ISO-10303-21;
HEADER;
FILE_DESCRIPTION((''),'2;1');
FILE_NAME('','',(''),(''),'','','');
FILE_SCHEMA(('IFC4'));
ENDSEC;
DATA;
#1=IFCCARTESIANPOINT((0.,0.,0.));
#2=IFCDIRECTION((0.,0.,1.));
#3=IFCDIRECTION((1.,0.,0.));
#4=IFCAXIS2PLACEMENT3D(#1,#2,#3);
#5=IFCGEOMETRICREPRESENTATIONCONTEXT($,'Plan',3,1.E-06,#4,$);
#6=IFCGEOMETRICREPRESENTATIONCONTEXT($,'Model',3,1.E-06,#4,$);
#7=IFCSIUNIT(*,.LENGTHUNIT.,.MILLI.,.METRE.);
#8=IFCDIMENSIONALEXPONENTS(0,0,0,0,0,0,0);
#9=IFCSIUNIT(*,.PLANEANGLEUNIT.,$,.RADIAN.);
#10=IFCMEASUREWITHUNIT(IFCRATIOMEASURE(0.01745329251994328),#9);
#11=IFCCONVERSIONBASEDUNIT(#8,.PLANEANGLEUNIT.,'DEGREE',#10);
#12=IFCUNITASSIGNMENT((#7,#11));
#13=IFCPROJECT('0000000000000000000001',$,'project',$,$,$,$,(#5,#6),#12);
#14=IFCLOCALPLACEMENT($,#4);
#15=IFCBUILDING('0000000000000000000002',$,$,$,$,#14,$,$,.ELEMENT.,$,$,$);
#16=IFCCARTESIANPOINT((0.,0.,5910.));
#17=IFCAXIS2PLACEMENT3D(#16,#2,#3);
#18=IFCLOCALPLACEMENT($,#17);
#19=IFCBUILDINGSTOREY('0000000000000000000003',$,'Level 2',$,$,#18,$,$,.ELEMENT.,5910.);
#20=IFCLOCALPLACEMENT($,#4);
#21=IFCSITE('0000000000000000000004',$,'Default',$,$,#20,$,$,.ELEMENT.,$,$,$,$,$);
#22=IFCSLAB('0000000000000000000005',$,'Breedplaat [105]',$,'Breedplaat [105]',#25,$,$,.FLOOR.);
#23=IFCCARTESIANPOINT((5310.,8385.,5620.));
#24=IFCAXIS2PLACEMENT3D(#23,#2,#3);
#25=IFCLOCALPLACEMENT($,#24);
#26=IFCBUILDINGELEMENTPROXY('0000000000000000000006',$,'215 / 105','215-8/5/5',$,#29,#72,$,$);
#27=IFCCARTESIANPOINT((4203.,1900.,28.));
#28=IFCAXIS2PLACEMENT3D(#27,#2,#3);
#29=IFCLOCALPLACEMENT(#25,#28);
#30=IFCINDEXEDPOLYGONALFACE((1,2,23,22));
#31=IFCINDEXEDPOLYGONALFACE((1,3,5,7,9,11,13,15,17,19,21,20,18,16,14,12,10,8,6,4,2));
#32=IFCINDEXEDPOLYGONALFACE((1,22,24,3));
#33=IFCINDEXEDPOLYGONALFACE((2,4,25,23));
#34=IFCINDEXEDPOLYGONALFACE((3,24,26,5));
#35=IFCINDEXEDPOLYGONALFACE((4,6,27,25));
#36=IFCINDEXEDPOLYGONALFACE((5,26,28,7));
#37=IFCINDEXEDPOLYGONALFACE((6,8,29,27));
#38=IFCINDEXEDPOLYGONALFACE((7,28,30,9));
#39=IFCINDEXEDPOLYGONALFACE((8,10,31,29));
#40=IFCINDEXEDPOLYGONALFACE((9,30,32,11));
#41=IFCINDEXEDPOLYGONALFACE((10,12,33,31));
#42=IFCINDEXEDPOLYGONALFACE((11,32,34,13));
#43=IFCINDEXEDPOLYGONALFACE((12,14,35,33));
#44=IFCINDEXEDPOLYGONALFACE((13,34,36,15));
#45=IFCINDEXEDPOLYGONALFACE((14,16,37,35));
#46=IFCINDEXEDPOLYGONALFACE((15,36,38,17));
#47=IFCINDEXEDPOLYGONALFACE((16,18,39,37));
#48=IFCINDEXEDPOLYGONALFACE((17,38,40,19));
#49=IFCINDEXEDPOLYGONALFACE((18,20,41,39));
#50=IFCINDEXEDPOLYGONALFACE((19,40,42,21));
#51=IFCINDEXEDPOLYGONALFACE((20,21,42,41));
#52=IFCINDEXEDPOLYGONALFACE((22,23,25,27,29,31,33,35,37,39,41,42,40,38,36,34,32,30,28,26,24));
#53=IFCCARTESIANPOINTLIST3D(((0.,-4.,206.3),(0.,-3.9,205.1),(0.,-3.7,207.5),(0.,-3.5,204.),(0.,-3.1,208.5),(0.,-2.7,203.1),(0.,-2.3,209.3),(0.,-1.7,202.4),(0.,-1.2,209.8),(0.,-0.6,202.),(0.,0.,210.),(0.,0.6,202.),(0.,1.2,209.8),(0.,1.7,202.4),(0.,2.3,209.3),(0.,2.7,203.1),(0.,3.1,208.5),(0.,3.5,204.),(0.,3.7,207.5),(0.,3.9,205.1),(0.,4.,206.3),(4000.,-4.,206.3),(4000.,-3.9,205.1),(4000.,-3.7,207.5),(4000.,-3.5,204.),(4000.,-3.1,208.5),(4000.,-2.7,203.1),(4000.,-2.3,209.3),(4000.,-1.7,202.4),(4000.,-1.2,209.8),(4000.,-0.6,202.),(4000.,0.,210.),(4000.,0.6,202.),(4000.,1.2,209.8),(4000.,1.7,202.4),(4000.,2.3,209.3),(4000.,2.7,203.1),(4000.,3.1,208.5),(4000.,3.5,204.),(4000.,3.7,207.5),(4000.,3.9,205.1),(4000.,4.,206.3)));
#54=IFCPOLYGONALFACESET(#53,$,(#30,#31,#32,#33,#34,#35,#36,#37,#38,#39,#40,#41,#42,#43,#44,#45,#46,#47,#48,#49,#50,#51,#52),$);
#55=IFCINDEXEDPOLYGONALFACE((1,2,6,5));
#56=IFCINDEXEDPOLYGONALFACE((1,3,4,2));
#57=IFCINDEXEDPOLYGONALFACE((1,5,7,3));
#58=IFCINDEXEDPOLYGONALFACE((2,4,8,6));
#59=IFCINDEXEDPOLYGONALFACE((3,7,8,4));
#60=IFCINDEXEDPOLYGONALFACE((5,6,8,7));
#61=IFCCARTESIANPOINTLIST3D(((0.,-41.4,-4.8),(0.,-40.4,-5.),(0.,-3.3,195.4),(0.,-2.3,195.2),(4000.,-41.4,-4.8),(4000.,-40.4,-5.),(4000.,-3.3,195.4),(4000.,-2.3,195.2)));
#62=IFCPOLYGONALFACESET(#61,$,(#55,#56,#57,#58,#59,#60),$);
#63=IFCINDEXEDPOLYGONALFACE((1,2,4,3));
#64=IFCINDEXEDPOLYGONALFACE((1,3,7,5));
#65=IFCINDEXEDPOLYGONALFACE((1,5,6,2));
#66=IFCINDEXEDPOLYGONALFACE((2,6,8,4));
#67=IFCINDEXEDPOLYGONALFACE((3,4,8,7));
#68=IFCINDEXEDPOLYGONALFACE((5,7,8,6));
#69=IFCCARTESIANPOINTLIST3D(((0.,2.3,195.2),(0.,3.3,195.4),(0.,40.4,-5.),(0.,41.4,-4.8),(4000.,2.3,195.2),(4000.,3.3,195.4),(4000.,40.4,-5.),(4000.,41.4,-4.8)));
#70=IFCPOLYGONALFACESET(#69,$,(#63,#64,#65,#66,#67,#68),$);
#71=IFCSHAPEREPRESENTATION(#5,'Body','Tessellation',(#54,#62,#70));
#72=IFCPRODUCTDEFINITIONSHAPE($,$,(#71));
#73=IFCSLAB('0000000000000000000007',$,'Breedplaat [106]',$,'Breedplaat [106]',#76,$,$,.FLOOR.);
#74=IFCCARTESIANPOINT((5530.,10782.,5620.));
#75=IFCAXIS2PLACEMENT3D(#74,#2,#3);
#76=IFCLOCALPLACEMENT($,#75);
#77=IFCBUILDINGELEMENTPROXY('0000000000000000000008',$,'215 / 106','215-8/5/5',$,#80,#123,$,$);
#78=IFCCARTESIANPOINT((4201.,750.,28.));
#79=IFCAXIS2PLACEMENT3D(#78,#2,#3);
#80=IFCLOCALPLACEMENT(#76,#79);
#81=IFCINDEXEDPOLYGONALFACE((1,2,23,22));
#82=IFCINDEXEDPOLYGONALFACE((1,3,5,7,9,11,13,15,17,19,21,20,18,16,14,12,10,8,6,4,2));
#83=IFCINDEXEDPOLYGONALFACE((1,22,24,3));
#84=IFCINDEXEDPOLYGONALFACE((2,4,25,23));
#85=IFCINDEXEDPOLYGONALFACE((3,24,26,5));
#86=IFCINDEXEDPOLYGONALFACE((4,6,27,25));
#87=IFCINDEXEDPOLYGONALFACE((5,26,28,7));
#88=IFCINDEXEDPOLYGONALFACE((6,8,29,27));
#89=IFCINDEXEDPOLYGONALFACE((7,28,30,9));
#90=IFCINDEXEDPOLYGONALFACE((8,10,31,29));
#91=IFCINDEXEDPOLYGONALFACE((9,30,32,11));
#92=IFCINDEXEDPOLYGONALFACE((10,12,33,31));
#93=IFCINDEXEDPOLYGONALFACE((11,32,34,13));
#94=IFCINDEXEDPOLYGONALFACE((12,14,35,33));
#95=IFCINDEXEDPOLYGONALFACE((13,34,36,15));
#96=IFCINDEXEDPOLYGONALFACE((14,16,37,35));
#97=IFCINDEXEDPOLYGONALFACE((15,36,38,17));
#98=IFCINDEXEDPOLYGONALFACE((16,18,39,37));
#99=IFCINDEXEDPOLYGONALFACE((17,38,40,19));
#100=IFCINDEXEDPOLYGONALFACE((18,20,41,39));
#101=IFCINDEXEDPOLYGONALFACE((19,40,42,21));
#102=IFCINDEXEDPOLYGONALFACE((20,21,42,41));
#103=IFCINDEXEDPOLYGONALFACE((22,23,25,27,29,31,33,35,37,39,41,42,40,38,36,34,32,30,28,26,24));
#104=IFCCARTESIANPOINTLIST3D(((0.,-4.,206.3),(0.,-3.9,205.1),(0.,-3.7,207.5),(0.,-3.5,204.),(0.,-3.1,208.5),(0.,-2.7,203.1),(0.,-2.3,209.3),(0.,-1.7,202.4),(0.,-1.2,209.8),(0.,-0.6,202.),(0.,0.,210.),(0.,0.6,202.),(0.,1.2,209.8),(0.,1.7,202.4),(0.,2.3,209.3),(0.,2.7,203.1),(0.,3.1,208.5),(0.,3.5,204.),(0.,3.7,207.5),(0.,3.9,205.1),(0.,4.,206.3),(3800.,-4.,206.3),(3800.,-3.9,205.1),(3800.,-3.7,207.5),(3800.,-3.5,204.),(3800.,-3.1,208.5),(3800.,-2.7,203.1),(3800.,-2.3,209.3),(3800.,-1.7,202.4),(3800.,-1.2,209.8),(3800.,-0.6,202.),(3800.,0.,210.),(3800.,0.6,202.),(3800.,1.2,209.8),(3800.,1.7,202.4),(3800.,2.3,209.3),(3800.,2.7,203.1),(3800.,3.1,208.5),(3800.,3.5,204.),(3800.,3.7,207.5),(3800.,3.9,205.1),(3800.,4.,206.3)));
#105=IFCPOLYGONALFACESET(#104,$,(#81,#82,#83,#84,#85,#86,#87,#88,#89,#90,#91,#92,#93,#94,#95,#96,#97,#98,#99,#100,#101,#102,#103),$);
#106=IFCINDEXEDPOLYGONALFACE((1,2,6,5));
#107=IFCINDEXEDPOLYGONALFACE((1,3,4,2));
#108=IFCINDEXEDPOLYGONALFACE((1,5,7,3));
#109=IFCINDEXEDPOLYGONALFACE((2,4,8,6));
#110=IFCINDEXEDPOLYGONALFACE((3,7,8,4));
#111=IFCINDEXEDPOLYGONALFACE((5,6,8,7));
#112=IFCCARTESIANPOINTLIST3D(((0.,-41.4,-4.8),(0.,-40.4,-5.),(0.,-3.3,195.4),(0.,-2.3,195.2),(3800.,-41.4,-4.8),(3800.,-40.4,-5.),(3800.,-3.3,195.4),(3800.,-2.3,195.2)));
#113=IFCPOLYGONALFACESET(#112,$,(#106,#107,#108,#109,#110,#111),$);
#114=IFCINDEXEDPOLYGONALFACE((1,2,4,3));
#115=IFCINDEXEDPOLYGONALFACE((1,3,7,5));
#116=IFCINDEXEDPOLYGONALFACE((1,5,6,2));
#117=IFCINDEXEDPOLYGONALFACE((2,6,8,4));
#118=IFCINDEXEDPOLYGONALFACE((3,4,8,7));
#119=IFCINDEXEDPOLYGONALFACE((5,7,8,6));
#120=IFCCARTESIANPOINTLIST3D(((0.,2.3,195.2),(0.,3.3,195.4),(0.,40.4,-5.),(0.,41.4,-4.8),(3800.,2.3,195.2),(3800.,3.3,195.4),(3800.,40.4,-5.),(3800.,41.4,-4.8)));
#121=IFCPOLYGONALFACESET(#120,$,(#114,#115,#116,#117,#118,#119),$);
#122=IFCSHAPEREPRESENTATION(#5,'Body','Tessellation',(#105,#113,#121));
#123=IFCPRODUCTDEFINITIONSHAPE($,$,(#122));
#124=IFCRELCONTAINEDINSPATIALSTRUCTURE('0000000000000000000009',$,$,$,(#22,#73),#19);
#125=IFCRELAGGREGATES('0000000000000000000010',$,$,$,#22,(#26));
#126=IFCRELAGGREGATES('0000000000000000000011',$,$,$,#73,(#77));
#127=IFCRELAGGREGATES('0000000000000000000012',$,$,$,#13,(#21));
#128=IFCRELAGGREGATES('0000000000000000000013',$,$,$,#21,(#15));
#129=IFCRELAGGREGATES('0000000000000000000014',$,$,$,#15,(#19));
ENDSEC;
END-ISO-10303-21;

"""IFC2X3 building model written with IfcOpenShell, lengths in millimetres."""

from ifc_helpers import new_model, entity, si_unit, converted_unit, frame, origin_with_axes, origin_2d_with_axis, place, context, project, spatial, rectangle, circle, extrude, element, aggregate, save


model = new_model("IFC2X3")

# Units and contexts
plan_context = context("Plan", 3, precision=1e-06, world=origin_with_axes())
model_context = context("Model", 3, precision=1e-06, world=origin_with_axes())
ifc_project = project(units=[si_unit("LENGTHUNIT", "METRE", prefix="MILLI"), converted_unit("PLANEANGLEUNIT", "DEGREE", entity("IfcRatioMeasure", 0.01745329251994328), si_unit("PLANEANGLEUNIT", "RADIAN"), dimensions=[0, 0, 0, 0, 0, 0, 0])], contexts=[plan_context, model_context])

# Site, building, storey
site_placement = place(None, origin_with_axes())
site = spatial("IfcSite", under=ifc_project, at=site_placement, Name="Default", CompositionType="ELEMENT")
building_placement = place(None, origin_with_axes())
building = spatial("IfcBuilding", under=site, at=building_placement, CompositionType="ELEMENT")
storey_placement = place(None, frame((0.0, 0.0, 5910.0), z_axis=(0.0, 0.0, 1.0), x_axis=(1.0, 0.0, 0.0)))
storey = spatial("IfcBuildingStorey", under=building, at=storey_placement, Name="Level 2", CompositionType="ELEMENT", Elevation=5910.0)

# Slabs, building element proxies
slab_1_placement = place(None, frame((5310.0, 8385.0, 5620.0), z_axis=(0.0, 0.0, 1.0), x_axis=(1.0, 0.0, 0.0)))
slab_1 = element("IfcSlab", 1, at=slab_1_placement, inside=storey, Name="Breedplaat [105]", ObjectType="Breedplaat [105]", PredefinedType="FLOOR")
proxy_1_placement = place(slab_1_placement, frame((4203.0, 1900.0, 28.0), z_axis=(0.0, 0.0, 1.0), x_axis=(1.0, 0.0, 0.0)))
proxy_1 = element("IfcBuildingElementProxy", 2, at=proxy_1_placement, Name="215 / 105", Description="215-8/5/5", context=plan_context, shape_type="SweptSolid", body=[
    extrude(circle(Radius=4.0, at=origin_2d_with_axis()), frame((0.0, 0.0, 206.0), z_axis=(1.0, 0.0, 0.0), x_axis=(0.0, 0.0, 1.0)), (0.0, 0.0, 1.0), 4000.0),
    extrude(rectangle(XDim=203.8, YDim=1.0, at=origin_2d_with_axis()), frame((0.0, -21.9, 95.2), z_axis=(1.0, 0.0, 0.0), x_axis=(0.0, 0.187112, 0.982339)), (0.0, 0.0, 1.0), 4000.0),
    extrude(rectangle(XDim=203.8, YDim=1.0, at=origin_2d_with_axis()), frame((0.0, 21.9, 95.2), z_axis=(1.0, 0.0, 0.0), x_axis=(0.0, -0.187112, 0.982339)), (0.0, 0.0, 1.0), 4000.0),
])
aggregate(slab_1, [proxy_1])
slab_2_placement = place(None, frame((5530.0, 10782.0, 5620.0), z_axis=(0.0, 0.0, 1.0), x_axis=(1.0, 0.0, 0.0)))
slab_2 = element("IfcSlab", 3, at=slab_2_placement, inside=storey, Name="Breedplaat [106]", ObjectType="Breedplaat [106]", PredefinedType="FLOOR")
proxy_2_placement = place(slab_2_placement, frame((4201.0, 750.0, 28.0), z_axis=(0.0, 0.0, 1.0), x_axis=(1.0, 0.0, 0.0)))
proxy_2 = element("IfcBuildingElementProxy", 4, at=proxy_2_placement, Name="215 / 106", Description="215-8/5/5", context=plan_context, shape_type="SweptSolid", body=[
    extrude(circle(Radius=4.0, at=origin_2d_with_axis()), frame((0.0, 0.0, 206.0), z_axis=(1.0, 0.0, 0.0), x_axis=(0.0, 0.0, 1.0)), (0.0, 0.0, 1.0), 3800.0),
    extrude(rectangle(XDim=203.8, YDim=1.0, at=origin_2d_with_axis()), frame((0.0, -21.9, 95.2), z_axis=(1.0, 0.0, 0.0), x_axis=(0.0, 0.187112, 0.982339)), (0.0, 0.0, 1.0), 3800.0),
    extrude(rectangle(XDim=203.8, YDim=1.0, at=origin_2d_with_axis()), frame((0.0, 21.9, 95.2), z_axis=(1.0, 0.0, 0.0), x_axis=(0.0, -0.187112, 0.982339)), (0.0, 0.0, 1.0), 3800.0),
])
aggregate(slab_2, [proxy_2])

save(model, "model.ifc")
